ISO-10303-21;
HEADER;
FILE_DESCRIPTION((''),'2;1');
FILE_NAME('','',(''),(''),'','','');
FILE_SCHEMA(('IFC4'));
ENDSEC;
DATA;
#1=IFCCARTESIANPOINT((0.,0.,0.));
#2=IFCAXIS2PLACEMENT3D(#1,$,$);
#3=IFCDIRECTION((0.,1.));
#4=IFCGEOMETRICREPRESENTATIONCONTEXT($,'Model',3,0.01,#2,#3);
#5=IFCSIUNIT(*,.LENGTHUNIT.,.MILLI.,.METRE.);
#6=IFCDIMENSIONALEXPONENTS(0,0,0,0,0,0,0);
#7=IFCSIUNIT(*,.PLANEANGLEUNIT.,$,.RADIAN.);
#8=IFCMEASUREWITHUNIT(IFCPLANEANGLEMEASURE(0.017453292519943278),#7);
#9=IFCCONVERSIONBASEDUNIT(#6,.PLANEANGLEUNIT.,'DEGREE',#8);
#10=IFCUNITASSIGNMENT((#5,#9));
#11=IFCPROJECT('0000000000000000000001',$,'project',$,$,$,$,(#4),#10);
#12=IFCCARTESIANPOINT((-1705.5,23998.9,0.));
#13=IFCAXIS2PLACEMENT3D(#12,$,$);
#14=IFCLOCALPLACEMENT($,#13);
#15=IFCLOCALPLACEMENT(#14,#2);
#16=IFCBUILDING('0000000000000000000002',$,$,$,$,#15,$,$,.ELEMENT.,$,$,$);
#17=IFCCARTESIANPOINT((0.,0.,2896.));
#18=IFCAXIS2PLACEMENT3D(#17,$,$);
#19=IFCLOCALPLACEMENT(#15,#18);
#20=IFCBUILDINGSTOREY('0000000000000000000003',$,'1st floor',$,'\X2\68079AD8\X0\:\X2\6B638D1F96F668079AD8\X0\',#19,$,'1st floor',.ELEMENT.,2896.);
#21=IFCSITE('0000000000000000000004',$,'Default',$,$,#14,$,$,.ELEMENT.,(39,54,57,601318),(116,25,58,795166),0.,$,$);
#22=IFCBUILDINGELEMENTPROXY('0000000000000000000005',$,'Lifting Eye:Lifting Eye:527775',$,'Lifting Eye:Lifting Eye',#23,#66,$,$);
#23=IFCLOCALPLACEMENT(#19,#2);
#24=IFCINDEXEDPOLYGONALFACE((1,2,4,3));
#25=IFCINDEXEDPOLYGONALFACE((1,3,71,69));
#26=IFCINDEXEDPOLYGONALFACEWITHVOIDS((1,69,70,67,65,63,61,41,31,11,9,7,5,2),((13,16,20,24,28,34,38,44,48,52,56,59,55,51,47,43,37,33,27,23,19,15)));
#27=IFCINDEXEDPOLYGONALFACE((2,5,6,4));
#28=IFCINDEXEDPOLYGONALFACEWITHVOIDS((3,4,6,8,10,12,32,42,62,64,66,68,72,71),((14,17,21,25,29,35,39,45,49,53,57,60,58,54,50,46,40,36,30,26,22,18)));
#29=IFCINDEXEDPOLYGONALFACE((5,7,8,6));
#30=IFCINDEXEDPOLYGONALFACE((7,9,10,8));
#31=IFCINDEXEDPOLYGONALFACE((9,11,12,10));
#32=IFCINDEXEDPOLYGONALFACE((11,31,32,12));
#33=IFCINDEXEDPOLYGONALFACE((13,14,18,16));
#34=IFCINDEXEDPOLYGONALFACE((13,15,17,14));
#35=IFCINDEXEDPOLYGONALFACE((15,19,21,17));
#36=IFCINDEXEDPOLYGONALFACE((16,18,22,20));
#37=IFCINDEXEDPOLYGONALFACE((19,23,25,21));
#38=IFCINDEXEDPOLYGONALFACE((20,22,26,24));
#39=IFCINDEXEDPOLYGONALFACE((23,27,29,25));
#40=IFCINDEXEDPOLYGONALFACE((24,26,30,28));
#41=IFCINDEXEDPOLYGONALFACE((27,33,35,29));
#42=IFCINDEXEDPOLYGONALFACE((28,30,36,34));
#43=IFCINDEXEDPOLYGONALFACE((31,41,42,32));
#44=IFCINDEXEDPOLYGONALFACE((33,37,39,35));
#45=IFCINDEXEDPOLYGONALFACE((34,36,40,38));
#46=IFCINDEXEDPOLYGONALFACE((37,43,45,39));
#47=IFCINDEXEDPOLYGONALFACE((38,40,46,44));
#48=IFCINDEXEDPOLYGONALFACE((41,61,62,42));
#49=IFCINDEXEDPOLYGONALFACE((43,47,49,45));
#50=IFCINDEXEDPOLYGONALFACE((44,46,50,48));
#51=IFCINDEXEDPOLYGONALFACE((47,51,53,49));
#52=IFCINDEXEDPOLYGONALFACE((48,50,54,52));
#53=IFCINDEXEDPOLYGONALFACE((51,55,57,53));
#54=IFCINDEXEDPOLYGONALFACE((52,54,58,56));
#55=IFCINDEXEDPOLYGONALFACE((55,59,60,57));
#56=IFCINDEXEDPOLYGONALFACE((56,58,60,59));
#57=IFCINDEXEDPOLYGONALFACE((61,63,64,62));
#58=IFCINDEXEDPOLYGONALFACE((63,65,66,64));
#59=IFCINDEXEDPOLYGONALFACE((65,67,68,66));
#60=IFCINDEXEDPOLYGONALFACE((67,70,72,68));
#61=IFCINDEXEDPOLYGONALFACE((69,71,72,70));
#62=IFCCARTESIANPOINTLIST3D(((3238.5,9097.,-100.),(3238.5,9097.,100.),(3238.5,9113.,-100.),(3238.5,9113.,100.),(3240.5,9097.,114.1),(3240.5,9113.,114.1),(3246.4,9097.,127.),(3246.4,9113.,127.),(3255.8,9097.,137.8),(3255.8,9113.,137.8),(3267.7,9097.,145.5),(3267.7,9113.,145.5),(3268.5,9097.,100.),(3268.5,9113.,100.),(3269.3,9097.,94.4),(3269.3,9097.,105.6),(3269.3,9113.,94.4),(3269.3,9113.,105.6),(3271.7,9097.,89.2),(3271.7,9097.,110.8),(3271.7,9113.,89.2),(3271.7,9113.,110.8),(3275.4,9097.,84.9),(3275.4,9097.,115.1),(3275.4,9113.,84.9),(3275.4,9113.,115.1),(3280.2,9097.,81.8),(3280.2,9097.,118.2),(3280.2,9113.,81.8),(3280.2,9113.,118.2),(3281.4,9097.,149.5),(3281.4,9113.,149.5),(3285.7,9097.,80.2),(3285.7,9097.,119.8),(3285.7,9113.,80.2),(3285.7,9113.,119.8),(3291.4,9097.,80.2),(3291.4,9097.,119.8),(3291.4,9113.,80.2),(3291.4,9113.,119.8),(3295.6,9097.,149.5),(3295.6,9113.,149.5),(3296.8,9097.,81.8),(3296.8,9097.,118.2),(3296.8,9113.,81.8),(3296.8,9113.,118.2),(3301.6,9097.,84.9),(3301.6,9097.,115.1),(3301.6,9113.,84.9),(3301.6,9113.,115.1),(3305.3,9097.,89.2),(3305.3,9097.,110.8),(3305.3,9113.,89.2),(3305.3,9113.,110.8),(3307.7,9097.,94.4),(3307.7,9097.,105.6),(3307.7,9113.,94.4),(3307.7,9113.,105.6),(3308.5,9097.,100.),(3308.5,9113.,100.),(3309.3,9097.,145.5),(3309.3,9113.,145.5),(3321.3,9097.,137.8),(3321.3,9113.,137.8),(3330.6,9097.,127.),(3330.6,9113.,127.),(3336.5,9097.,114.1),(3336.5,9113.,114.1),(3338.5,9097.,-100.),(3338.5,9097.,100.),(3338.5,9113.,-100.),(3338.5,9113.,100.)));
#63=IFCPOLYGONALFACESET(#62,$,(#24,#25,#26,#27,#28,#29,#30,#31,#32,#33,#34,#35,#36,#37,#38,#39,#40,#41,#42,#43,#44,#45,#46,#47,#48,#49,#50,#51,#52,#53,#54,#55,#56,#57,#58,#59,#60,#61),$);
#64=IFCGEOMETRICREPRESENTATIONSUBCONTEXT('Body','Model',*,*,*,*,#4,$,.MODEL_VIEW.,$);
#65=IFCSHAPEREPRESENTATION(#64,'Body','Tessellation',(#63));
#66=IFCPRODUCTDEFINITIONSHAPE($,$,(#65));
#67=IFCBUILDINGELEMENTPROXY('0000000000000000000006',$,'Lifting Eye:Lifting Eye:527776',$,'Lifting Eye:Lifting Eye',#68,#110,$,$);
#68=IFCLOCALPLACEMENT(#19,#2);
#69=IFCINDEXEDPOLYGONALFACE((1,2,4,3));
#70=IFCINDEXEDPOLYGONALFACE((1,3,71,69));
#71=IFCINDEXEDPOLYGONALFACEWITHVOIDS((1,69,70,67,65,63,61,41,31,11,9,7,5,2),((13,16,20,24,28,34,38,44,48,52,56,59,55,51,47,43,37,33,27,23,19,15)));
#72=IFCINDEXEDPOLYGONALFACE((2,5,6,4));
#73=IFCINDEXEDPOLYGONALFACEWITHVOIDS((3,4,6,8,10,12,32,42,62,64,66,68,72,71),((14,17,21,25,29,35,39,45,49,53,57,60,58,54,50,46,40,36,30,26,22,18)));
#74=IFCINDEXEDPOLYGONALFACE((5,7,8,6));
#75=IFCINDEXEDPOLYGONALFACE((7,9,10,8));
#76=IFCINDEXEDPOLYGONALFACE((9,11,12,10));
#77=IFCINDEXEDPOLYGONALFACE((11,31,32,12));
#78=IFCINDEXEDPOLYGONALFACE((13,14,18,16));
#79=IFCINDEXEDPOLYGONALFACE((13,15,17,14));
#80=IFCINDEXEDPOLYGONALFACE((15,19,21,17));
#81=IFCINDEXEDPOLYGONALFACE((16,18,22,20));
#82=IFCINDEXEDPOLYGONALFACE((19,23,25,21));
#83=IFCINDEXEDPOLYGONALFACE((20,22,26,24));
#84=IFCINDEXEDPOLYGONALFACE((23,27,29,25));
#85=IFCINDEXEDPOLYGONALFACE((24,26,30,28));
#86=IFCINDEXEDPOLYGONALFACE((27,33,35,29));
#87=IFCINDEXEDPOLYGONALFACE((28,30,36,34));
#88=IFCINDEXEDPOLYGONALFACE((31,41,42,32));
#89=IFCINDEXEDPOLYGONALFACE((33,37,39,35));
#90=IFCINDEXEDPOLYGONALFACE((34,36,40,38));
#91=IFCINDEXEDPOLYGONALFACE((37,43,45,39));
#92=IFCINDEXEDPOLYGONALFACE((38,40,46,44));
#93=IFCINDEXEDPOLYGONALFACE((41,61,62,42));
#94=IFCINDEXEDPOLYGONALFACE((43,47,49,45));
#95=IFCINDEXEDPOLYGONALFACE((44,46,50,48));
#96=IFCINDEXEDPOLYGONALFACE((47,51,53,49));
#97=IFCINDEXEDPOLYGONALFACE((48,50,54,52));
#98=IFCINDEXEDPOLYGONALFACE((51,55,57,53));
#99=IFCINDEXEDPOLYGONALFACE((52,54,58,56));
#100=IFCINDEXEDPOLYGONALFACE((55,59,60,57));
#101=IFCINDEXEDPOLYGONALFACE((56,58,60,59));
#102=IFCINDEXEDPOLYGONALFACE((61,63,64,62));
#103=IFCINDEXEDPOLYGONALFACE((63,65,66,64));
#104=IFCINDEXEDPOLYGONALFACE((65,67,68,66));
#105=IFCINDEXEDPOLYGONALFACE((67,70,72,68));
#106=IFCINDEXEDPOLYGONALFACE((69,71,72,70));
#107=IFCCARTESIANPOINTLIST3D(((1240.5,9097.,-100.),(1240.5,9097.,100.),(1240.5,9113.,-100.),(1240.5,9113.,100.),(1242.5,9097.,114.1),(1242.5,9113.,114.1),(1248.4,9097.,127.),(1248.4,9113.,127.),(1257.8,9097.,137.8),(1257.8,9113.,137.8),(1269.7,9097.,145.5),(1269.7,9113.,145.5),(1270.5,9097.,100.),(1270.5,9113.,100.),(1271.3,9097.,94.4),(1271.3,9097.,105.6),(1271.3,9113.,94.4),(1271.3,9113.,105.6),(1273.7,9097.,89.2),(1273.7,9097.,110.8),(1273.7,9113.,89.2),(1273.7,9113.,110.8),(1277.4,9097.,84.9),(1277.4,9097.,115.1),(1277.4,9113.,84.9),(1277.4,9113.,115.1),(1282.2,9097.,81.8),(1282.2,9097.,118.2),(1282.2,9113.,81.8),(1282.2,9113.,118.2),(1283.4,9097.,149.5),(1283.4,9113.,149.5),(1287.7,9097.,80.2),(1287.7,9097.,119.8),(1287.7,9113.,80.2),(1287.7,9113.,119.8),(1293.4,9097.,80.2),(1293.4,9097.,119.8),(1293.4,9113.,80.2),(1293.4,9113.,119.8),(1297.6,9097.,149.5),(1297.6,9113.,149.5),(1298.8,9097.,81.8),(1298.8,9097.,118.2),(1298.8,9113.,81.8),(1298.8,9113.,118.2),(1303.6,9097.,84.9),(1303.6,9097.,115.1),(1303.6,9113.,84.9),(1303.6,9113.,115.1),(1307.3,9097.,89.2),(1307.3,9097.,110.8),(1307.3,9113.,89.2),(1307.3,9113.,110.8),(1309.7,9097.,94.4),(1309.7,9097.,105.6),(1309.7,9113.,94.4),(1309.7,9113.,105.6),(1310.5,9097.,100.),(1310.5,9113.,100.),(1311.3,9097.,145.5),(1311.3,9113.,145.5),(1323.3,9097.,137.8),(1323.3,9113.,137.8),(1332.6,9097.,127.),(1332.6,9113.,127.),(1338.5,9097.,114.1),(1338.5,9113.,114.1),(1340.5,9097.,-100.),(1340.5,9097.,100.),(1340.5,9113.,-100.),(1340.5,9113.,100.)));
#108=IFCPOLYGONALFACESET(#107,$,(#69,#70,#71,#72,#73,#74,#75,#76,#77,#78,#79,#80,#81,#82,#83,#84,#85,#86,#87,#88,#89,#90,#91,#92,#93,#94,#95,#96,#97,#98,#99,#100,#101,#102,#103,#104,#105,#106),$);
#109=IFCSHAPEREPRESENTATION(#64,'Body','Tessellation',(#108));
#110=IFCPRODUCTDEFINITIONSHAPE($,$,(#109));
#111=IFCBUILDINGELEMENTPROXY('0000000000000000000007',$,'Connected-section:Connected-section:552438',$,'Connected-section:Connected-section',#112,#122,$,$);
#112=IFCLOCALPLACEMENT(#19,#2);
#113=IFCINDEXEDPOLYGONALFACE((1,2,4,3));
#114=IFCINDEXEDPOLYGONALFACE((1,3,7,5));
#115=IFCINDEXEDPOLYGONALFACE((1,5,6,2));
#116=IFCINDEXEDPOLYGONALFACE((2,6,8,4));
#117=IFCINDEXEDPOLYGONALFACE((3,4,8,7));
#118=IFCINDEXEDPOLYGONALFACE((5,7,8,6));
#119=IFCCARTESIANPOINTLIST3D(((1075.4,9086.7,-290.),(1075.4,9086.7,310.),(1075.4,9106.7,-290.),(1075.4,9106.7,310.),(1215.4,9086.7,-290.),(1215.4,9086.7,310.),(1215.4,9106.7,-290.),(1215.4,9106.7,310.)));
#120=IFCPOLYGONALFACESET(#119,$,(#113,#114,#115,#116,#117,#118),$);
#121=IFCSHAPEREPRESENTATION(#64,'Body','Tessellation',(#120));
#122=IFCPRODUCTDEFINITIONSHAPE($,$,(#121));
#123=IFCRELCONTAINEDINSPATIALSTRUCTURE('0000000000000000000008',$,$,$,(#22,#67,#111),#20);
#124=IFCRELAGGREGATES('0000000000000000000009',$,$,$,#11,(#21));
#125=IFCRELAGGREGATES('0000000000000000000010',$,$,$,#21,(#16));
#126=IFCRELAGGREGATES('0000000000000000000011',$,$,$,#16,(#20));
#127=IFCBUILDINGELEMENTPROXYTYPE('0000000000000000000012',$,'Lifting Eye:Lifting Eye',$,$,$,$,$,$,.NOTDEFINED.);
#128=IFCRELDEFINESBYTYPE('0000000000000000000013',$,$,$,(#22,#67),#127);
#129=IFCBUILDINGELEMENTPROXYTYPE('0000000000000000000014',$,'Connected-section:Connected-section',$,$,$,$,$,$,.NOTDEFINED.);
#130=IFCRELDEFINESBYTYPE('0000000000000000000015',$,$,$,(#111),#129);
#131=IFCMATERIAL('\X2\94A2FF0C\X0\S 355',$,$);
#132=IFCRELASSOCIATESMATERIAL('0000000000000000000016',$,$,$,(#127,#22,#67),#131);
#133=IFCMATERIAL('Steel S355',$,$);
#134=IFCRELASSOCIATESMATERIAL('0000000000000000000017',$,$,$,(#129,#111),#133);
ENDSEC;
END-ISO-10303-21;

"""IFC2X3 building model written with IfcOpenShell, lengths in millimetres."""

from ifc_helpers import new_model, entity, si_unit, converted_unit, direction, frame, frame_2d, origin, place, context, subcontext, project, spatial, polyline, circle_curve, parameter, trimmed, segment, composite_curve, rectangle, outline, extrude, source, transform, mapped, material, type_object, type_shapes, element, save


model = new_model("IFC2X3")

# Units and contexts
model_context = context("Model", 3, precision=0.01, world=origin(), true_north=direction((0.0, 1.0)))
body_context = subcontext(model_context, "Body", "Model", "MODEL_VIEW")
ifc_project = project(units=[si_unit("LENGTHUNIT", "METRE", prefix="MILLI"), converted_unit("PLANEANGLEUNIT", "DEGREE", entity("IfcPlaneAngleMeasure", 0.017453292519943278), si_unit("PLANEANGLEUNIT", "RADIAN"), dimensions=[0, 0, 0, 0, 0, 0, 0])], contexts=[model_context])

# Site, building, storey
site_placement = place(None, frame((-1705.5, 23998.9, 0.0)))
site = spatial("IfcSite", under=ifc_project, at=site_placement, Name="Default", CompositionType="ELEMENT", RefLatitude=(39, 54, 57, 601318), RefLongitude=(116, 25, 58, 795166), RefElevation=0.0)
building_placement = place(site_placement, origin())
building = spatial("IfcBuilding", under=site, at=building_placement, CompositionType="ELEMENT")
storey_placement = place(building_placement, frame((0.0, 0.0, 2896.0)))
storey = spatial("IfcBuildingStorey", under=building, at=storey_placement, Name="1st floor", ObjectType="标高:正负零标高", LongName="1st floor", CompositionType="ELEMENT", Elevation=2896.0)

# Shared definitions
ifc_material_1 = material(Name="Steel S355")

# Building element proxies
ifc_material_2 = material(Name="钢，S 355")
building_element_proxy_type_1 = type_object("IfcBuildingElementProxyType", Name="Lifting Eye:Lifting Eye", PredefinedType="NOTDEFINED", material=ifc_material_2)
shared_shape_1 = source(origin(), body_context, "Body", "SweptSolid", [
    extrude(outline(composite_curve([segment(polyline([(-100.0, -50.0), (100.0, -50.0)]), True, "CONTINUOUS"), segment(polyline([(100.0, -50.0), (100.0, 50.0)]), True, "CONTINUOUS"), segment(polyline([(100.0, 50.0), (-100.0, 50.0)]), True, "CONTINUOUS"), segment(trimmed(circle_curve(frame_2d((-100.0, 0.0), x_axis=(0.0, -1.0)), 50.0), [parameter(180.0)], [parameter(0.0)], True, "PARAMETER"), True, "CONTINUOUS")], self_intersect=False), holes=[composite_curve([segment(trimmed(circle_curve(frame_2d((-100.0, 0.0), x_axis=(0.0, -1.0)), 20.0), [parameter(180.0)], [parameter(360.0)], True, "PARAMETER"), False, "CONTINUOUS"), segment(trimmed(circle_curve(frame_2d((-100.0, 0.0), x_axis=(0.0, -1.0)), 20.0), [parameter(0.0)], [parameter(180.0)], True, "PARAMETER"), False, "CONTINUOUS")], self_intersect=False)]), frame((0.0, 17.0, -17.0), z_axis=(0.0, 1.0, 0.0), x_axis=(0.0, 0.0, -1.0)), (0.0, 0.0, 1.0), 16.0),
])
type_shapes(building_element_proxy_type_1, [shared_shape_1])
for number, where, name in (
    (1, (3288.5, 9080.0, 17.0), "Lifting Eye:Lifting Eye:527775"),
    (2, (1290.5, 9080.0, 17.0), "Lifting Eye:Lifting Eye:527776"),
):
    element("IfcBuildingElementProxy", number, at=place(storey_placement, frame(where)), inside=storey, type_object=building_element_proxy_type_1, material=ifc_material_2, Name=name, ObjectType="Lifting Eye:Lifting Eye", context=body_context, shape_type="MappedRepresentation", body=[
        mapped(shared_shape_1, transform((0.0, 0.0, 0.0), scale=1.0)),
    ])
building_element_proxy_type_2 = type_object("IfcBuildingElementProxyType", Name="Connected-section:Connected-section", PredefinedType="NOTDEFINED", material=ifc_material_1)
shared_shape_2 = source(origin(), body_context, "Body", "SweptSolid", [
    extrude(rectangle(XDim=20.0, YDim=140.0, at=frame_2d((0.0, 0.0), x_axis=(1.0, 0.0))), frame((70.0, 10.0, 0.0), z_axis=(0.0, 0.0, 1.0), x_axis=(0.0, 1.0, 0.0)), (0.0, 0.0, 1.0), 600.0),
])
type_shapes(building_element_proxy_type_2, [shared_shape_2])
proxy_1_placement = place(storey_placement, frame((1075.4, 9086.7, -290.0)))
element("IfcBuildingElementProxy", 3, at=proxy_1_placement, inside=storey, type_object=building_element_proxy_type_2, material=ifc_material_1, Name="Connected-section:Connected-section:552438", ObjectType="Connected-section:Connected-section", context=body_context, shape_type="MappedRepresentation", body=[
    mapped(shared_shape_2, transform((0.0, 0.0, 0.0), scale=1.0)),
])

save(model, "model.ifc")
